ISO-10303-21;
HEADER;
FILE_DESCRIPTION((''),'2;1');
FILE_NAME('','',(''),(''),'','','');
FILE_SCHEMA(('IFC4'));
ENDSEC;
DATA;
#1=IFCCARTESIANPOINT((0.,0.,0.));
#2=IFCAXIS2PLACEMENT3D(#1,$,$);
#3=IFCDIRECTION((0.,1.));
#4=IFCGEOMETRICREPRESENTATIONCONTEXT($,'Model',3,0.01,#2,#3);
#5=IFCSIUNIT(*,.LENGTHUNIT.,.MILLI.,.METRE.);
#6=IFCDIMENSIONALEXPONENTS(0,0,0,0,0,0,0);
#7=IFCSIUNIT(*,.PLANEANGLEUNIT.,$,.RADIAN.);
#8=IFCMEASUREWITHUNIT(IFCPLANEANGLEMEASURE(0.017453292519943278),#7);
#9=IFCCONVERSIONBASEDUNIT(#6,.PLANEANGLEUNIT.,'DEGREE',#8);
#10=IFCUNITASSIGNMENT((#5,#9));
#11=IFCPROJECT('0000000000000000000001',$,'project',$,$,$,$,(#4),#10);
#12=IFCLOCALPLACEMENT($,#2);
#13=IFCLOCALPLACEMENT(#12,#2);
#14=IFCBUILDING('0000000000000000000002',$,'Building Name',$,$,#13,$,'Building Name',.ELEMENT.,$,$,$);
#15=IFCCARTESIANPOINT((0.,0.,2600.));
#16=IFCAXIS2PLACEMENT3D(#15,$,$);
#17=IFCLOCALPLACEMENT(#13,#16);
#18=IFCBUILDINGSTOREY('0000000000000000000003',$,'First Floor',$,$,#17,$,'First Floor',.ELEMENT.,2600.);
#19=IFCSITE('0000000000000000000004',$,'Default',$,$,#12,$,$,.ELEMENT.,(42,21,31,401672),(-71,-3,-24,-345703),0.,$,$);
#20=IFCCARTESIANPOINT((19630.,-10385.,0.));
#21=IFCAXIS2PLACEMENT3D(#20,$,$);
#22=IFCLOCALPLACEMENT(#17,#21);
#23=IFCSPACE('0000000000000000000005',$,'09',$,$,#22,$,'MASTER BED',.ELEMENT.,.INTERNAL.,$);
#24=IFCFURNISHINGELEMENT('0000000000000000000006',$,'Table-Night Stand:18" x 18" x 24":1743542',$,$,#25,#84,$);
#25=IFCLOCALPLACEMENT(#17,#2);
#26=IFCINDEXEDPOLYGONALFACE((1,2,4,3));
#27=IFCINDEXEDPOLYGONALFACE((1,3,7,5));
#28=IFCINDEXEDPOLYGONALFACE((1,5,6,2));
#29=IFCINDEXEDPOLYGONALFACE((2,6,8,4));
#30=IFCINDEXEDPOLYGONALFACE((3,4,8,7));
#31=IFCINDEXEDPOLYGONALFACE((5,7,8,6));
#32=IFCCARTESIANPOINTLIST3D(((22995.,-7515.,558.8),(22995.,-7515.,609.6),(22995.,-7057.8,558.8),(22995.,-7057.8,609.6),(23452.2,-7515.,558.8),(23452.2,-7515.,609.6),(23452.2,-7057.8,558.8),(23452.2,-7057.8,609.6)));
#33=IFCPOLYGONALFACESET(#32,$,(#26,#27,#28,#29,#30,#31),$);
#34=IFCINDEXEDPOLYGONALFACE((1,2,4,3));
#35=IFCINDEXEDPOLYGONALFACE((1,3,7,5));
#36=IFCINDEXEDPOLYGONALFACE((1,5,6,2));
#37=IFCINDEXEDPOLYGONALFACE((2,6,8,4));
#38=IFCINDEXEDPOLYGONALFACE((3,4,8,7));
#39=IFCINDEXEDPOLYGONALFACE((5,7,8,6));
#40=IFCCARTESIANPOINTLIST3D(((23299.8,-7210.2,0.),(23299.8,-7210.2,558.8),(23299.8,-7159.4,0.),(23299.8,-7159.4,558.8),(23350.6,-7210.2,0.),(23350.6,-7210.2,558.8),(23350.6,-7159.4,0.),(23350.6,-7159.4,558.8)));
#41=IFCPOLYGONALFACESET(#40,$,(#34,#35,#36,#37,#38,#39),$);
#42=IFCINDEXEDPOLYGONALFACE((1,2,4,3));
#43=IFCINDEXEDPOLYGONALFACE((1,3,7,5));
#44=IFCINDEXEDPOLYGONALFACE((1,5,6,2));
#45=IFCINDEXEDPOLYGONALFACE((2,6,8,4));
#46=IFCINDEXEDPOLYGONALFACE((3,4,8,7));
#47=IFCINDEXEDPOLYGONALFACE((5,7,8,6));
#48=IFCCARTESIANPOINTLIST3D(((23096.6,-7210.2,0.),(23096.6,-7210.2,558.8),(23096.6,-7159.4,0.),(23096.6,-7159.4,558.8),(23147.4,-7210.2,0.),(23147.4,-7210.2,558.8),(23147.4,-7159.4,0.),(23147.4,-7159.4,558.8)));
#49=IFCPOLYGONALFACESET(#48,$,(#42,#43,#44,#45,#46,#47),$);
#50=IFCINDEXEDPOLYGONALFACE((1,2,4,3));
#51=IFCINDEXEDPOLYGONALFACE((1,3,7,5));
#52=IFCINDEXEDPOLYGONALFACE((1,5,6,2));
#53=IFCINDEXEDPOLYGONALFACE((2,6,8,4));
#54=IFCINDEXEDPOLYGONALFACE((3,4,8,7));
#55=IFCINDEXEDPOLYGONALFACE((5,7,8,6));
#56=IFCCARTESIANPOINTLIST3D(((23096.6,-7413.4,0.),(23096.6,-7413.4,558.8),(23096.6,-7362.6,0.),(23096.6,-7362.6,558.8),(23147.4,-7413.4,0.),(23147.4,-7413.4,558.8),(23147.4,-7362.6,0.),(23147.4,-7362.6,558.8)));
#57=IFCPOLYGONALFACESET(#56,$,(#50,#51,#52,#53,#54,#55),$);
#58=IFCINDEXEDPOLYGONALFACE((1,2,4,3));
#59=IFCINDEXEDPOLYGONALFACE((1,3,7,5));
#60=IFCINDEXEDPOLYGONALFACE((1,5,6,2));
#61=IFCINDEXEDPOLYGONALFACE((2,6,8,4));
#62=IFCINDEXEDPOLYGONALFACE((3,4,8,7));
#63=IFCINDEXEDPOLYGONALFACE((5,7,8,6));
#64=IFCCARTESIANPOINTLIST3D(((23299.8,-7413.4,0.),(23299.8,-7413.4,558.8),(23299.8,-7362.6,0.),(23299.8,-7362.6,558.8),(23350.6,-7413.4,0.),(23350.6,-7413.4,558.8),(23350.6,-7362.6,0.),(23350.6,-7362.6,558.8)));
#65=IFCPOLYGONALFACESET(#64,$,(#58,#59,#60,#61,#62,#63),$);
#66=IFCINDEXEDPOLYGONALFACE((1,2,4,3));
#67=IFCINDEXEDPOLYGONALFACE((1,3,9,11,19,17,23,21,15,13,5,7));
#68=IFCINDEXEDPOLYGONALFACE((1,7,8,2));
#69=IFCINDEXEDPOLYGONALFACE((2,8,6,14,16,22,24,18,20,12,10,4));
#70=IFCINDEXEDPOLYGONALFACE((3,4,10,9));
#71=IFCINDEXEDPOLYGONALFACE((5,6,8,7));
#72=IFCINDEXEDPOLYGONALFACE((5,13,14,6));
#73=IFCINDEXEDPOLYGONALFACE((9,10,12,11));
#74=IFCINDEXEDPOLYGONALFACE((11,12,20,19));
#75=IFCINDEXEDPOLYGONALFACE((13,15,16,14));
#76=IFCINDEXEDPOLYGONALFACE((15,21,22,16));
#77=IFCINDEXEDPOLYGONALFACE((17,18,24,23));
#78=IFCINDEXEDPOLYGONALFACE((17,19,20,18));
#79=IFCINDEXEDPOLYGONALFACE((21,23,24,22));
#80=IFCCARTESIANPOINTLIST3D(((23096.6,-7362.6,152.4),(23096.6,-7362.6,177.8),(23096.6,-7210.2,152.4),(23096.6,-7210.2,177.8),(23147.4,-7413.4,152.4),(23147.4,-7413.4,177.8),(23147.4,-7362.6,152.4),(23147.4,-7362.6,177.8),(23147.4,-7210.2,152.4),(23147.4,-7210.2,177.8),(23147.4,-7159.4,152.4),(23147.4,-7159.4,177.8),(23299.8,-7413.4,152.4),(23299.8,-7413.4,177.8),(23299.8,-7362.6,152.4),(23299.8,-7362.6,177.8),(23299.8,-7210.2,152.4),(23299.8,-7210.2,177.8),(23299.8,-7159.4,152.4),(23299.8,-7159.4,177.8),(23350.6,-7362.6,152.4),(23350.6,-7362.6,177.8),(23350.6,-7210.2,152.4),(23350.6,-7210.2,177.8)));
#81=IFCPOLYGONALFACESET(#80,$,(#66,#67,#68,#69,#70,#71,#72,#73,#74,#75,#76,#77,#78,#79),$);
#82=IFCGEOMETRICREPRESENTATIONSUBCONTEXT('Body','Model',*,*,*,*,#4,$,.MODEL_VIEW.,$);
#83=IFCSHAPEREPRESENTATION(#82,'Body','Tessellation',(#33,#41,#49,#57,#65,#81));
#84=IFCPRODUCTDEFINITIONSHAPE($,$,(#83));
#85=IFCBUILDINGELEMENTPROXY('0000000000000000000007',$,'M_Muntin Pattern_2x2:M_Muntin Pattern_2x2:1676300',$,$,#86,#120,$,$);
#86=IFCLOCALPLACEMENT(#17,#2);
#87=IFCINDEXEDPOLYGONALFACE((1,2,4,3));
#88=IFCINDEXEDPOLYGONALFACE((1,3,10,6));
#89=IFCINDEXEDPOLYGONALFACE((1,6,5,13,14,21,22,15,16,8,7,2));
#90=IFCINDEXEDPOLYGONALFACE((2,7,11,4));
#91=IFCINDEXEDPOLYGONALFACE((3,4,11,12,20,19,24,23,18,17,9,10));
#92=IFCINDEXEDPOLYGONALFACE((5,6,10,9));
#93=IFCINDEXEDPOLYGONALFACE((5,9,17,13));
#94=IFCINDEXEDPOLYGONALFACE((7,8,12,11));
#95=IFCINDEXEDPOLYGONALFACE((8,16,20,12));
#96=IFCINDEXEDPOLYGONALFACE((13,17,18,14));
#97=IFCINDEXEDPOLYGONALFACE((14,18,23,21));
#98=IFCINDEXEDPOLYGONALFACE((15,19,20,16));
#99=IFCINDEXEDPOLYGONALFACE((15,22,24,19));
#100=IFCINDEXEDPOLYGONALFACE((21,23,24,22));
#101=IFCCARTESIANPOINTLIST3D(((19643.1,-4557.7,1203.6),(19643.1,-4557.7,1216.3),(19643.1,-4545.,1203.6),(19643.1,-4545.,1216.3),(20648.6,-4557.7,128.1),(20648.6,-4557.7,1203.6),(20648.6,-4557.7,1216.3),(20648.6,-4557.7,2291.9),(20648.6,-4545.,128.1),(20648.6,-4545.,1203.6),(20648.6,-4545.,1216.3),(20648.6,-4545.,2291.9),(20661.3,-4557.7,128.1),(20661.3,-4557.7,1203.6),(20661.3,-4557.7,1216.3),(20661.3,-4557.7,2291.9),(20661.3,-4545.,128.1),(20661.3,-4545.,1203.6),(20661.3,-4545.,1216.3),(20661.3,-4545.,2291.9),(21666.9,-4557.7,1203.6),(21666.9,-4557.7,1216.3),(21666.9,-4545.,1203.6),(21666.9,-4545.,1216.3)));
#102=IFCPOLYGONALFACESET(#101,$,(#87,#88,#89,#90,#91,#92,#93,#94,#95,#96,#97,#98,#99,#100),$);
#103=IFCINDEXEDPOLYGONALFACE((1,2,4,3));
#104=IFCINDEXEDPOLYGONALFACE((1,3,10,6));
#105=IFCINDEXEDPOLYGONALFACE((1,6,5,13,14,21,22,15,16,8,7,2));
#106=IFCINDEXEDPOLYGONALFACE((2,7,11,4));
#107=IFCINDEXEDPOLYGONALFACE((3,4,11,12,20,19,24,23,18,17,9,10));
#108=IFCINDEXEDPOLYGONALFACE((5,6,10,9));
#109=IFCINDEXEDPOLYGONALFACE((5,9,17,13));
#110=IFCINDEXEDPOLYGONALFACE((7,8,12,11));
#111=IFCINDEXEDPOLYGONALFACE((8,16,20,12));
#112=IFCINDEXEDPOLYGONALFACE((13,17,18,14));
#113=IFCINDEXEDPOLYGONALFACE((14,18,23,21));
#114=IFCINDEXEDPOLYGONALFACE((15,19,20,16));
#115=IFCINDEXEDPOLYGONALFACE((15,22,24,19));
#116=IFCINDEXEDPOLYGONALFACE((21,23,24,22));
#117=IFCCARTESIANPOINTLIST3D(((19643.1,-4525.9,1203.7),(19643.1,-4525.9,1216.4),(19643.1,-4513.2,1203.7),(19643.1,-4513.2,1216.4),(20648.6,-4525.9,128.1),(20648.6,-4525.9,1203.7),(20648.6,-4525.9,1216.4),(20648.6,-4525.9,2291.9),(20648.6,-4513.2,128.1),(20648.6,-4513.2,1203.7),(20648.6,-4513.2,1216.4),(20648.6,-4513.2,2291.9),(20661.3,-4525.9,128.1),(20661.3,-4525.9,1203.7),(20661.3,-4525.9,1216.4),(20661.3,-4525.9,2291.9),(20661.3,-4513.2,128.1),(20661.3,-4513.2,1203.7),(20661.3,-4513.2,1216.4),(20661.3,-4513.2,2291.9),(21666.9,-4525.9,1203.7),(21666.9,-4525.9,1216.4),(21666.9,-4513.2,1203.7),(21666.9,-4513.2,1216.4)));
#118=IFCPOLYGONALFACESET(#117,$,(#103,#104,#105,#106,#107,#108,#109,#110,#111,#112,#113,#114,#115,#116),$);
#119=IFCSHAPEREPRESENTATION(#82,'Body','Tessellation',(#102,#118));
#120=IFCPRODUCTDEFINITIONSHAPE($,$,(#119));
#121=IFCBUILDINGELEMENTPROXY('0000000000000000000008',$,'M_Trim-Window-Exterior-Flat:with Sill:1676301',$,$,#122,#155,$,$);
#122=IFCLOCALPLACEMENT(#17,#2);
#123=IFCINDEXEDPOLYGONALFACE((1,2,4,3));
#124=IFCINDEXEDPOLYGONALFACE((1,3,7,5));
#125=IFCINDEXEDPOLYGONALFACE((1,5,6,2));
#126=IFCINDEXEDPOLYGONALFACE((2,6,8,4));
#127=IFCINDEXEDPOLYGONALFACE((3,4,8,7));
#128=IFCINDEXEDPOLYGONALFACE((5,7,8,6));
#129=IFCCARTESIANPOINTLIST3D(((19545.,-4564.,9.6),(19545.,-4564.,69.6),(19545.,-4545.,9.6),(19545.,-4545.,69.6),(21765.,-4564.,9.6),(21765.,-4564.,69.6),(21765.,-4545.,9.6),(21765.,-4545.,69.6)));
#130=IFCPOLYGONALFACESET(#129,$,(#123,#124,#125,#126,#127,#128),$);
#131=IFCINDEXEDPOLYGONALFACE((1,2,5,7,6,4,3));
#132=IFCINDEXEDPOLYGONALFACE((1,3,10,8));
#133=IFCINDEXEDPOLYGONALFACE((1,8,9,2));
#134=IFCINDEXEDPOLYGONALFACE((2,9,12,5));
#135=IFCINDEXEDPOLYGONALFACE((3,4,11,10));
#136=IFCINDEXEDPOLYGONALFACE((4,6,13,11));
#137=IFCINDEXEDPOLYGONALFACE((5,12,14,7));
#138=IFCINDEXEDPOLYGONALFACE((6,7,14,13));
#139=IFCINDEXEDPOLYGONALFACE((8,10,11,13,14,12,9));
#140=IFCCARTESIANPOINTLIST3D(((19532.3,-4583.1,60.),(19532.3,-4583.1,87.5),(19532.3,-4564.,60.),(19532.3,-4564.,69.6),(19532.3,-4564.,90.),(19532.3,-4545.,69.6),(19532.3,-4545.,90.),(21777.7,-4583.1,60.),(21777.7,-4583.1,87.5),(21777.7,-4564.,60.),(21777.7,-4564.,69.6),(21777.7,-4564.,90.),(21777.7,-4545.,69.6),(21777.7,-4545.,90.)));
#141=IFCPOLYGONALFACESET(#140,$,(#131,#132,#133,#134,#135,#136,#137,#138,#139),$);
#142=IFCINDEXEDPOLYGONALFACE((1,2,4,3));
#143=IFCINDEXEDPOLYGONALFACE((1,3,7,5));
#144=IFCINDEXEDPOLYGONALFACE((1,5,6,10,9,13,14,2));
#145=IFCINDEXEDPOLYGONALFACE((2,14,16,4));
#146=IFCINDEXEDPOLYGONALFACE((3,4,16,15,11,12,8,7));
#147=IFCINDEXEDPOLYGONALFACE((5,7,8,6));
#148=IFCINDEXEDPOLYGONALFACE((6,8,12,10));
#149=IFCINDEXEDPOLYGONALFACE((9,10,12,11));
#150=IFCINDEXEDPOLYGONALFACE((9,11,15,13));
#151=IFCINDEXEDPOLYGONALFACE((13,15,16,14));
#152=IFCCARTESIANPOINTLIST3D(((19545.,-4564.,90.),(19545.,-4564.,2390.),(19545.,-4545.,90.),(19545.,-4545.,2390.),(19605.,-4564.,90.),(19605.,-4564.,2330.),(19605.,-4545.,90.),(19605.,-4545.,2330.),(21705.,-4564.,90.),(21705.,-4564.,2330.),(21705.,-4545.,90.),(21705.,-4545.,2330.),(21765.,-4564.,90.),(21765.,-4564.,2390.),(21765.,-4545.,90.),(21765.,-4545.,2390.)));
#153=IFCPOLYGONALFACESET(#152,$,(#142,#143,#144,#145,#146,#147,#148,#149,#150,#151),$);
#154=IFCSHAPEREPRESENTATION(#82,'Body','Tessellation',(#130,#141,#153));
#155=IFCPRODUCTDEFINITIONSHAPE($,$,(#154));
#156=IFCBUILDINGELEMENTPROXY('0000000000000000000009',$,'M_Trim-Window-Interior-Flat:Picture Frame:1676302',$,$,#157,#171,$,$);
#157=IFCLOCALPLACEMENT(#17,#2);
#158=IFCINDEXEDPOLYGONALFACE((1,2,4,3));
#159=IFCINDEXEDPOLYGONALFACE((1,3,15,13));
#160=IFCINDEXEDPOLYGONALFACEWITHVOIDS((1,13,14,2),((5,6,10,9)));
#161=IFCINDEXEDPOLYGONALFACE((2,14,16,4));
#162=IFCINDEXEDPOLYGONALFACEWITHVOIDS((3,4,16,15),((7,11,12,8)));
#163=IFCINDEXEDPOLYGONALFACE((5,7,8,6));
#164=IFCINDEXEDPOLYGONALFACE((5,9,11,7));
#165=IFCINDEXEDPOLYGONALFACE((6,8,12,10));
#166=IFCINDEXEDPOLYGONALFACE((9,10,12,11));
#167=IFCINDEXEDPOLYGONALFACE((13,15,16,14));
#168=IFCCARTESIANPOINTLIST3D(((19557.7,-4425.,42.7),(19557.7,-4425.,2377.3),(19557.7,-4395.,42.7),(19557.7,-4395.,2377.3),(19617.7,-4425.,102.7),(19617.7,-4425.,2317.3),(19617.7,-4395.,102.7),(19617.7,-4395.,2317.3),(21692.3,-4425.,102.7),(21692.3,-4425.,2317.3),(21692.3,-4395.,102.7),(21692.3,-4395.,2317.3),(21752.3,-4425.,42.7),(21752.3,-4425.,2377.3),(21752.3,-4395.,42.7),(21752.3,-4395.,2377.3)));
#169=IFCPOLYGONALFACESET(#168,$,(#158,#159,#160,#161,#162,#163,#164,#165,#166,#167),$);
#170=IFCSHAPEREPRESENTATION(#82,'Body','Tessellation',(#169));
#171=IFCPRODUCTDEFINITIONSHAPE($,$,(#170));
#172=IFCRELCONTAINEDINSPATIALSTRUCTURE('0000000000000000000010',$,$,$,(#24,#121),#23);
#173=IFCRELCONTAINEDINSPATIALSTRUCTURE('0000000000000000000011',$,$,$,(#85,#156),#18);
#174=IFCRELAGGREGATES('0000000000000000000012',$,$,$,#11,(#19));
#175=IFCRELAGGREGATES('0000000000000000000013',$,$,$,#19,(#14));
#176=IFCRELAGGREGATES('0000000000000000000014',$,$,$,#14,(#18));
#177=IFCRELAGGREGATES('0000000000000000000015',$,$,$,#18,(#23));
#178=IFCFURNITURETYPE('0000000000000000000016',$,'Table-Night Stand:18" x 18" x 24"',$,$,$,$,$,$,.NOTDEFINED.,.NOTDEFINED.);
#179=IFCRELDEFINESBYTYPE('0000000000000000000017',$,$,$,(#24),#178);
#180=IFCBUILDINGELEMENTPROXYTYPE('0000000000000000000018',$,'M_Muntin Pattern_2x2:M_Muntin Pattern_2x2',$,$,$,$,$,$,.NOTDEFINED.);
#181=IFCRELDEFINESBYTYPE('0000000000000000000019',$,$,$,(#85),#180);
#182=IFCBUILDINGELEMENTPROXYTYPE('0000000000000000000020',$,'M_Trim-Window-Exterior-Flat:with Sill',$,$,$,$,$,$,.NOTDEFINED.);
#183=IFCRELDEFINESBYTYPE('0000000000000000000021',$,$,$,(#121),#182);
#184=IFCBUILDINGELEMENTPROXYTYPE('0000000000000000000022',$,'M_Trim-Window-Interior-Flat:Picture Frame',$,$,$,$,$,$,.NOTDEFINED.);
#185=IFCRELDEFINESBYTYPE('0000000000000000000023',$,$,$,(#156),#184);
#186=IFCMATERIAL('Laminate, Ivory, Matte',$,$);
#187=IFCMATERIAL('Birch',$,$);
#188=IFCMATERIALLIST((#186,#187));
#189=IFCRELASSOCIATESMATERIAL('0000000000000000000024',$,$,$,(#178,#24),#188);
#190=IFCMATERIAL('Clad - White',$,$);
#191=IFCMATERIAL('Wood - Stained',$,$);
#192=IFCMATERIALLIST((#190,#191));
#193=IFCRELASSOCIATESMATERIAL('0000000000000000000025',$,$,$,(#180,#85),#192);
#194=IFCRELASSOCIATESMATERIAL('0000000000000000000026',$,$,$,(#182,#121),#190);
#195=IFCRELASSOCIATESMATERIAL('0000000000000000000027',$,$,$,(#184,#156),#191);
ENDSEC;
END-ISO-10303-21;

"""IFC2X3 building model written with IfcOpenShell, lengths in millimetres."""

from ifc_helpers import new_model, entity, si_unit, converted_unit, direction, frame, frame_2d, origin, origin_2d_with_axis, place, context, subcontext, project, spatial, polyline, rectangle, outline, extrude, source, transform, mapped, material, material_list, type_object, type_shapes, element, save


model = new_model("IFC2X3")

# Units and contexts
model_context = context("Model", 3, precision=0.01, world=origin(), true_north=direction((0.0, 1.0)))
body_context = subcontext(model_context, "Body", "Model", "MODEL_VIEW")
ifc_project = project(units=[si_unit("LENGTHUNIT", "METRE", prefix="MILLI"), converted_unit("PLANEANGLEUNIT", "DEGREE", entity("IfcPlaneAngleMeasure", 0.017453292519943278), si_unit("PLANEANGLEUNIT", "RADIAN"), dimensions=[0, 0, 0, 0, 0, 0, 0])], contexts=[model_context])

# Site, building, storey
site_placement = place(None, origin())
site = spatial("IfcSite", under=ifc_project, at=site_placement, Name="Default", CompositionType="ELEMENT", RefLatitude=(42, 21, 31, 401672), RefLongitude=(-71, -3, -24, -345703), RefElevation=0.0)
building_placement = place(site_placement, origin())
building = spatial("IfcBuilding", under=site, at=building_placement, Name="Building Name", LongName="Building Name", CompositionType="ELEMENT")
storey_placement = place(building_placement, frame((0.0, 0.0, 2600.0)))
storey = spatial("IfcBuildingStorey", under=building, at=storey_placement, Name="First Floor", LongName="First Floor", CompositionType="ELEMENT", Elevation=2600.0)

# Shared definitions
space_1_placement = place(storey_placement, frame((19630.0, -10385.0, 0.0)))
space_1 = spatial("IfcSpace", under=storey, at=space_1_placement, Name="09", LongName="MASTER BED", CompositionType="ELEMENT", InteriorOrExteriorSpace="INTERNAL")

# Furnishing element
ifc_material_1 = material(Name="Laminate, Ivory, Matte")
ifc_material_2 = material(Name="Birch")
ifc_material_list_1 = material_list([ifc_material_1, ifc_material_2])
furniture_type_1 = type_object("IfcFurnitureType", Name="Table-Night Stand:18\" x 18\" x 24\"", AssemblyPlace="NOTDEFINED", material=ifc_material_list_1)
shared_shape_1 = source(origin(), body_context, "Body", "SweptSolid", [
    extrude(rectangle(XDim=457.2, YDim=457.2, at=origin_2d_with_axis()), frame((232.3, 228.6, 558.8), z_axis=(0.0, 0.0, 1.0), x_axis=(0.0, 1.0, 0.0)), (0.0, 0.0, 1.0), 50.8),
    extrude(rectangle(XDim=50.8, YDim=50.8, at=origin_2d_with_axis()), frame((333.9, 330.2, 0.0), z_axis=(0.0, 0.0, 1.0), x_axis=(-1.0, 0.0, 0.0)), (0.0, 0.0, 1.0), 558.8),
    extrude(rectangle(XDim=50.8, YDim=50.8, at=frame_2d((0.0, 0.0), x_axis=(1.0, 0.0))), frame((130.7, 330.2, 0.0), z_axis=(0.0, 0.0, 1.0), x_axis=(-1.0, 0.0, 0.0)), (0.0, 0.0, 1.0), 558.8),
    extrude(rectangle(XDim=50.8, YDim=50.8, at=frame_2d((0.0, 0.0), x_axis=(1.0, 0.0))), frame((130.7, 127.0, 0.0), z_axis=(0.0, 0.0, 1.0), x_axis=(-1.0, 0.0, 0.0)), (0.0, 0.0, 1.0), 558.8),
    extrude(rectangle(XDim=50.8, YDim=50.8, at=frame_2d((0.0, 0.0), x_axis=(1.0, 0.0))), frame((333.9, 127.0, 0.0), z_axis=(0.0, 0.0, 1.0), x_axis=(-1.0, 0.0, 0.0)), (0.0, 0.0, 1.0), 558.8),
    extrude(outline(polyline([(-127.0, 76.2), (-127.0, -76.2), (-76.2, -76.2), (-76.2, -127.0), (76.2, -127.0), (76.2, -76.2), (127.0, -76.2), (127.0, 76.2), (76.2, 76.2), (76.2, 127.0), (-76.2, 127.0), (-76.2, 76.2), (-127.0, 76.2)])), frame((232.3, 228.6, 152.4), z_axis=(0.0, 0.0, -1.0), x_axis=(0.0, -1.0, 0.0)), (0.0, 0.0, -1.0), 25.4),
])
type_shapes(furniture_type_1, [shared_shape_1])
for number, where, name in (
    (1, (3361.3, 2870.0, 0.0), "Table-Night Stand:18\" x 18\" x 24\":1743542"),
):
    element("IfcFurnishingElement", number, at=place(space_1_placement, frame(where)), inside=space_1, type_object=furniture_type_1, material=ifc_material_list_1, Name=name, context=body_context, shape_type="MappedRepresentation", body=[
        mapped(shared_shape_1, transform((0.0, 0.0, 0.0), scale=1.0)),
    ])

# Building element proxies
ifc_material_3 = material(Name="Clad - White")
ifc_material_4 = material(Name="Wood - Stained")
ifc_material_list_2 = material_list([ifc_material_3, ifc_material_4])
building_element_proxy_type_1 = type_object("IfcBuildingElementProxyType", Name="M_Muntin Pattern_2x2:M_Muntin Pattern_2x2", PredefinedType="NOTDEFINED", material=ifc_material_list_2)
shared_shape_2 = source(origin(), body_context, "Body", "SweptSolid", [
    extrude(outline(polyline([(6.4, -6.4), (1081.9, -6.4), (1081.9, 6.3), (6.4, 6.3), (6.4, 1011.9), (-6.3, 1011.9), (-6.3, 6.3), (-1081.9, 6.3), (-1081.9, -6.4), (-6.3, -6.4), (-6.3, -1011.9), (6.4, -1011.9), (6.4, -6.4)])), frame((0.0, -22.2, 1081.9), z_axis=(0.0, 1.0, 0.0), x_axis=(0.0, 0.0, 1.0)), (0.0, 0.0, 1.0), 12.7),
    extrude(outline(polyline([(6.4, -6.4), (1081.9, -6.4), (1081.9, 6.3), (6.4, 6.3), (6.4, 1011.9), (-6.3, 1011.9), (-6.3, 6.3), (-1081.9, 6.3), (-1081.9, -6.4), (-6.3, -6.4), (-6.3, -1011.9), (6.4, -1011.9), (6.4, -6.4)])), frame((0.0, 9.5, 1081.9), z_axis=(0.0, 1.0, 0.0), x_axis=(0.0, 0.0, 1.0)), (0.0, 0.0, 1.0), 12.7),
])
type_shapes(building_element_proxy_type_1, [shared_shape_2])
proxy_1_placement = place(storey_placement, frame((20655.0, -4535.5, 128.1)))
element("IfcBuildingElementProxy", 2, at=proxy_1_placement, inside=storey, type_object=building_element_proxy_type_1, material=ifc_material_list_2, Name="M_Muntin Pattern_2x2:M_Muntin Pattern_2x2:1676300", context=body_context, shape_type="MappedRepresentation", body=[
    mapped(shared_shape_2, transform((0.0, 0.0, 0.0), scale=1.0)),
])
building_element_proxy_type_2 = type_object("IfcBuildingElementProxyType", Name="M_Trim-Window-Exterior-Flat:with Sill", PredefinedType="NOTDEFINED", material=ifc_material_3)
shared_shape_3 = source(origin(), body_context, "Body", "SweptSolid", [
    extrude(rectangle(XDim=2220.0, YDim=60.0, at=frame_2d((0.0, 0.0), x_axis=(1.0, 0.0))), frame((0.0, -2290.4, 0.0), z_axis=(0.0, 0.0, 1.0), x_axis=(-1.0, 0.0, 0.0)), (0.0, 0.0, 1.0), 19.0),
    extrude(outline(polyline([(-19.0, -15.2), (0.0, -15.2), (0.0, -5.7), (19.0, -5.7), (19.0, 14.8), (0.0, 14.8), (-19.0, 12.3), (-19.0, -15.2)])), frame((-1122.7, -2254.8, 19.0), z_axis=(1.0, 0.0, 0.0), x_axis=(0.0, 0.0, -1.0)), (0.0, 0.0, 1.0), 2245.4),
    extrude(outline(polyline([(-1165.0, -1110.0), (1135.0, -1110.0), (1135.0, -1050.0), (-1105.0, -1050.0), (-1105.0, 1050.0), (1135.0, 1050.0), (1135.0, 1110.0), (-1165.0, 1110.0), (-1165.0, -1110.0)])), frame((0.0, -1105.0, 0.0), z_axis=(0.0, 0.0, 1.0), x_axis=(0.0, -1.0, 0.0)), (0.0, 0.0, 1.0), 19.0),
])
type_shapes(building_element_proxy_type_2, [shared_shape_3])
proxy_2_placement = place(space_1_placement, frame((1025.0, 5840.0, 2330.0), z_axis=(0.0, -1.0, 0.0), x_axis=(1.0, 0.0, 0.0)))
element("IfcBuildingElementProxy", 3, at=proxy_2_placement, inside=space_1, type_object=building_element_proxy_type_2, material=ifc_material_3, Name="M_Trim-Window-Exterior-Flat:with Sill:1676301", context=body_context, shape_type="MappedRepresentation", body=[
    mapped(shared_shape_3, transform((0.0, 0.0, 0.0), scale=1.0)),
])
building_element_proxy_type_3 = type_object("IfcBuildingElementProxyType", Name="M_Trim-Window-Interior-Flat:Picture Frame", PredefinedType="NOTDEFINED", material=ifc_material_4)
shared_shape_4 = source(origin(), body_context, "Body", "SweptSolid", [
    extrude(outline(polyline([(-1097.3, -1167.3), (1097.3, -1167.3), (1097.3, 1167.3), (-1097.3, 1167.3), (-1097.3, -1167.3)]), holes=[polyline([(-1037.3, -1107.3), (-1037.3, 1107.3), (1037.3, 1107.3), (1037.3, -1107.3), (-1037.3, -1107.3)])]), frame((0.0, -1120.0, 0.0), z_axis=(0.0, 0.0, 1.0), x_axis=(-1.0, 0.0, 0.0)), (0.0, 0.0, 1.0), 30.0),
])
type_shapes(building_element_proxy_type_3, [shared_shape_4])
proxy_3_placement = place(storey_placement, frame((20655.0, -4425.0, 2330.0), z_axis=(0.0, 1.0, 0.0), x_axis=(-1.0, 0.0, 0.0)))
element("IfcBuildingElementProxy", 4, at=proxy_3_placement, inside=storey, type_object=building_element_proxy_type_3, material=ifc_material_4, Name="M_Trim-Window-Interior-Flat:Picture Frame:1676302", context=body_context, shape_type="MappedRepresentation", body=[
    mapped(shared_shape_4, transform((0.0, 0.0, 0.0), scale=1.0)),
])

save(model, "model.ifc")
